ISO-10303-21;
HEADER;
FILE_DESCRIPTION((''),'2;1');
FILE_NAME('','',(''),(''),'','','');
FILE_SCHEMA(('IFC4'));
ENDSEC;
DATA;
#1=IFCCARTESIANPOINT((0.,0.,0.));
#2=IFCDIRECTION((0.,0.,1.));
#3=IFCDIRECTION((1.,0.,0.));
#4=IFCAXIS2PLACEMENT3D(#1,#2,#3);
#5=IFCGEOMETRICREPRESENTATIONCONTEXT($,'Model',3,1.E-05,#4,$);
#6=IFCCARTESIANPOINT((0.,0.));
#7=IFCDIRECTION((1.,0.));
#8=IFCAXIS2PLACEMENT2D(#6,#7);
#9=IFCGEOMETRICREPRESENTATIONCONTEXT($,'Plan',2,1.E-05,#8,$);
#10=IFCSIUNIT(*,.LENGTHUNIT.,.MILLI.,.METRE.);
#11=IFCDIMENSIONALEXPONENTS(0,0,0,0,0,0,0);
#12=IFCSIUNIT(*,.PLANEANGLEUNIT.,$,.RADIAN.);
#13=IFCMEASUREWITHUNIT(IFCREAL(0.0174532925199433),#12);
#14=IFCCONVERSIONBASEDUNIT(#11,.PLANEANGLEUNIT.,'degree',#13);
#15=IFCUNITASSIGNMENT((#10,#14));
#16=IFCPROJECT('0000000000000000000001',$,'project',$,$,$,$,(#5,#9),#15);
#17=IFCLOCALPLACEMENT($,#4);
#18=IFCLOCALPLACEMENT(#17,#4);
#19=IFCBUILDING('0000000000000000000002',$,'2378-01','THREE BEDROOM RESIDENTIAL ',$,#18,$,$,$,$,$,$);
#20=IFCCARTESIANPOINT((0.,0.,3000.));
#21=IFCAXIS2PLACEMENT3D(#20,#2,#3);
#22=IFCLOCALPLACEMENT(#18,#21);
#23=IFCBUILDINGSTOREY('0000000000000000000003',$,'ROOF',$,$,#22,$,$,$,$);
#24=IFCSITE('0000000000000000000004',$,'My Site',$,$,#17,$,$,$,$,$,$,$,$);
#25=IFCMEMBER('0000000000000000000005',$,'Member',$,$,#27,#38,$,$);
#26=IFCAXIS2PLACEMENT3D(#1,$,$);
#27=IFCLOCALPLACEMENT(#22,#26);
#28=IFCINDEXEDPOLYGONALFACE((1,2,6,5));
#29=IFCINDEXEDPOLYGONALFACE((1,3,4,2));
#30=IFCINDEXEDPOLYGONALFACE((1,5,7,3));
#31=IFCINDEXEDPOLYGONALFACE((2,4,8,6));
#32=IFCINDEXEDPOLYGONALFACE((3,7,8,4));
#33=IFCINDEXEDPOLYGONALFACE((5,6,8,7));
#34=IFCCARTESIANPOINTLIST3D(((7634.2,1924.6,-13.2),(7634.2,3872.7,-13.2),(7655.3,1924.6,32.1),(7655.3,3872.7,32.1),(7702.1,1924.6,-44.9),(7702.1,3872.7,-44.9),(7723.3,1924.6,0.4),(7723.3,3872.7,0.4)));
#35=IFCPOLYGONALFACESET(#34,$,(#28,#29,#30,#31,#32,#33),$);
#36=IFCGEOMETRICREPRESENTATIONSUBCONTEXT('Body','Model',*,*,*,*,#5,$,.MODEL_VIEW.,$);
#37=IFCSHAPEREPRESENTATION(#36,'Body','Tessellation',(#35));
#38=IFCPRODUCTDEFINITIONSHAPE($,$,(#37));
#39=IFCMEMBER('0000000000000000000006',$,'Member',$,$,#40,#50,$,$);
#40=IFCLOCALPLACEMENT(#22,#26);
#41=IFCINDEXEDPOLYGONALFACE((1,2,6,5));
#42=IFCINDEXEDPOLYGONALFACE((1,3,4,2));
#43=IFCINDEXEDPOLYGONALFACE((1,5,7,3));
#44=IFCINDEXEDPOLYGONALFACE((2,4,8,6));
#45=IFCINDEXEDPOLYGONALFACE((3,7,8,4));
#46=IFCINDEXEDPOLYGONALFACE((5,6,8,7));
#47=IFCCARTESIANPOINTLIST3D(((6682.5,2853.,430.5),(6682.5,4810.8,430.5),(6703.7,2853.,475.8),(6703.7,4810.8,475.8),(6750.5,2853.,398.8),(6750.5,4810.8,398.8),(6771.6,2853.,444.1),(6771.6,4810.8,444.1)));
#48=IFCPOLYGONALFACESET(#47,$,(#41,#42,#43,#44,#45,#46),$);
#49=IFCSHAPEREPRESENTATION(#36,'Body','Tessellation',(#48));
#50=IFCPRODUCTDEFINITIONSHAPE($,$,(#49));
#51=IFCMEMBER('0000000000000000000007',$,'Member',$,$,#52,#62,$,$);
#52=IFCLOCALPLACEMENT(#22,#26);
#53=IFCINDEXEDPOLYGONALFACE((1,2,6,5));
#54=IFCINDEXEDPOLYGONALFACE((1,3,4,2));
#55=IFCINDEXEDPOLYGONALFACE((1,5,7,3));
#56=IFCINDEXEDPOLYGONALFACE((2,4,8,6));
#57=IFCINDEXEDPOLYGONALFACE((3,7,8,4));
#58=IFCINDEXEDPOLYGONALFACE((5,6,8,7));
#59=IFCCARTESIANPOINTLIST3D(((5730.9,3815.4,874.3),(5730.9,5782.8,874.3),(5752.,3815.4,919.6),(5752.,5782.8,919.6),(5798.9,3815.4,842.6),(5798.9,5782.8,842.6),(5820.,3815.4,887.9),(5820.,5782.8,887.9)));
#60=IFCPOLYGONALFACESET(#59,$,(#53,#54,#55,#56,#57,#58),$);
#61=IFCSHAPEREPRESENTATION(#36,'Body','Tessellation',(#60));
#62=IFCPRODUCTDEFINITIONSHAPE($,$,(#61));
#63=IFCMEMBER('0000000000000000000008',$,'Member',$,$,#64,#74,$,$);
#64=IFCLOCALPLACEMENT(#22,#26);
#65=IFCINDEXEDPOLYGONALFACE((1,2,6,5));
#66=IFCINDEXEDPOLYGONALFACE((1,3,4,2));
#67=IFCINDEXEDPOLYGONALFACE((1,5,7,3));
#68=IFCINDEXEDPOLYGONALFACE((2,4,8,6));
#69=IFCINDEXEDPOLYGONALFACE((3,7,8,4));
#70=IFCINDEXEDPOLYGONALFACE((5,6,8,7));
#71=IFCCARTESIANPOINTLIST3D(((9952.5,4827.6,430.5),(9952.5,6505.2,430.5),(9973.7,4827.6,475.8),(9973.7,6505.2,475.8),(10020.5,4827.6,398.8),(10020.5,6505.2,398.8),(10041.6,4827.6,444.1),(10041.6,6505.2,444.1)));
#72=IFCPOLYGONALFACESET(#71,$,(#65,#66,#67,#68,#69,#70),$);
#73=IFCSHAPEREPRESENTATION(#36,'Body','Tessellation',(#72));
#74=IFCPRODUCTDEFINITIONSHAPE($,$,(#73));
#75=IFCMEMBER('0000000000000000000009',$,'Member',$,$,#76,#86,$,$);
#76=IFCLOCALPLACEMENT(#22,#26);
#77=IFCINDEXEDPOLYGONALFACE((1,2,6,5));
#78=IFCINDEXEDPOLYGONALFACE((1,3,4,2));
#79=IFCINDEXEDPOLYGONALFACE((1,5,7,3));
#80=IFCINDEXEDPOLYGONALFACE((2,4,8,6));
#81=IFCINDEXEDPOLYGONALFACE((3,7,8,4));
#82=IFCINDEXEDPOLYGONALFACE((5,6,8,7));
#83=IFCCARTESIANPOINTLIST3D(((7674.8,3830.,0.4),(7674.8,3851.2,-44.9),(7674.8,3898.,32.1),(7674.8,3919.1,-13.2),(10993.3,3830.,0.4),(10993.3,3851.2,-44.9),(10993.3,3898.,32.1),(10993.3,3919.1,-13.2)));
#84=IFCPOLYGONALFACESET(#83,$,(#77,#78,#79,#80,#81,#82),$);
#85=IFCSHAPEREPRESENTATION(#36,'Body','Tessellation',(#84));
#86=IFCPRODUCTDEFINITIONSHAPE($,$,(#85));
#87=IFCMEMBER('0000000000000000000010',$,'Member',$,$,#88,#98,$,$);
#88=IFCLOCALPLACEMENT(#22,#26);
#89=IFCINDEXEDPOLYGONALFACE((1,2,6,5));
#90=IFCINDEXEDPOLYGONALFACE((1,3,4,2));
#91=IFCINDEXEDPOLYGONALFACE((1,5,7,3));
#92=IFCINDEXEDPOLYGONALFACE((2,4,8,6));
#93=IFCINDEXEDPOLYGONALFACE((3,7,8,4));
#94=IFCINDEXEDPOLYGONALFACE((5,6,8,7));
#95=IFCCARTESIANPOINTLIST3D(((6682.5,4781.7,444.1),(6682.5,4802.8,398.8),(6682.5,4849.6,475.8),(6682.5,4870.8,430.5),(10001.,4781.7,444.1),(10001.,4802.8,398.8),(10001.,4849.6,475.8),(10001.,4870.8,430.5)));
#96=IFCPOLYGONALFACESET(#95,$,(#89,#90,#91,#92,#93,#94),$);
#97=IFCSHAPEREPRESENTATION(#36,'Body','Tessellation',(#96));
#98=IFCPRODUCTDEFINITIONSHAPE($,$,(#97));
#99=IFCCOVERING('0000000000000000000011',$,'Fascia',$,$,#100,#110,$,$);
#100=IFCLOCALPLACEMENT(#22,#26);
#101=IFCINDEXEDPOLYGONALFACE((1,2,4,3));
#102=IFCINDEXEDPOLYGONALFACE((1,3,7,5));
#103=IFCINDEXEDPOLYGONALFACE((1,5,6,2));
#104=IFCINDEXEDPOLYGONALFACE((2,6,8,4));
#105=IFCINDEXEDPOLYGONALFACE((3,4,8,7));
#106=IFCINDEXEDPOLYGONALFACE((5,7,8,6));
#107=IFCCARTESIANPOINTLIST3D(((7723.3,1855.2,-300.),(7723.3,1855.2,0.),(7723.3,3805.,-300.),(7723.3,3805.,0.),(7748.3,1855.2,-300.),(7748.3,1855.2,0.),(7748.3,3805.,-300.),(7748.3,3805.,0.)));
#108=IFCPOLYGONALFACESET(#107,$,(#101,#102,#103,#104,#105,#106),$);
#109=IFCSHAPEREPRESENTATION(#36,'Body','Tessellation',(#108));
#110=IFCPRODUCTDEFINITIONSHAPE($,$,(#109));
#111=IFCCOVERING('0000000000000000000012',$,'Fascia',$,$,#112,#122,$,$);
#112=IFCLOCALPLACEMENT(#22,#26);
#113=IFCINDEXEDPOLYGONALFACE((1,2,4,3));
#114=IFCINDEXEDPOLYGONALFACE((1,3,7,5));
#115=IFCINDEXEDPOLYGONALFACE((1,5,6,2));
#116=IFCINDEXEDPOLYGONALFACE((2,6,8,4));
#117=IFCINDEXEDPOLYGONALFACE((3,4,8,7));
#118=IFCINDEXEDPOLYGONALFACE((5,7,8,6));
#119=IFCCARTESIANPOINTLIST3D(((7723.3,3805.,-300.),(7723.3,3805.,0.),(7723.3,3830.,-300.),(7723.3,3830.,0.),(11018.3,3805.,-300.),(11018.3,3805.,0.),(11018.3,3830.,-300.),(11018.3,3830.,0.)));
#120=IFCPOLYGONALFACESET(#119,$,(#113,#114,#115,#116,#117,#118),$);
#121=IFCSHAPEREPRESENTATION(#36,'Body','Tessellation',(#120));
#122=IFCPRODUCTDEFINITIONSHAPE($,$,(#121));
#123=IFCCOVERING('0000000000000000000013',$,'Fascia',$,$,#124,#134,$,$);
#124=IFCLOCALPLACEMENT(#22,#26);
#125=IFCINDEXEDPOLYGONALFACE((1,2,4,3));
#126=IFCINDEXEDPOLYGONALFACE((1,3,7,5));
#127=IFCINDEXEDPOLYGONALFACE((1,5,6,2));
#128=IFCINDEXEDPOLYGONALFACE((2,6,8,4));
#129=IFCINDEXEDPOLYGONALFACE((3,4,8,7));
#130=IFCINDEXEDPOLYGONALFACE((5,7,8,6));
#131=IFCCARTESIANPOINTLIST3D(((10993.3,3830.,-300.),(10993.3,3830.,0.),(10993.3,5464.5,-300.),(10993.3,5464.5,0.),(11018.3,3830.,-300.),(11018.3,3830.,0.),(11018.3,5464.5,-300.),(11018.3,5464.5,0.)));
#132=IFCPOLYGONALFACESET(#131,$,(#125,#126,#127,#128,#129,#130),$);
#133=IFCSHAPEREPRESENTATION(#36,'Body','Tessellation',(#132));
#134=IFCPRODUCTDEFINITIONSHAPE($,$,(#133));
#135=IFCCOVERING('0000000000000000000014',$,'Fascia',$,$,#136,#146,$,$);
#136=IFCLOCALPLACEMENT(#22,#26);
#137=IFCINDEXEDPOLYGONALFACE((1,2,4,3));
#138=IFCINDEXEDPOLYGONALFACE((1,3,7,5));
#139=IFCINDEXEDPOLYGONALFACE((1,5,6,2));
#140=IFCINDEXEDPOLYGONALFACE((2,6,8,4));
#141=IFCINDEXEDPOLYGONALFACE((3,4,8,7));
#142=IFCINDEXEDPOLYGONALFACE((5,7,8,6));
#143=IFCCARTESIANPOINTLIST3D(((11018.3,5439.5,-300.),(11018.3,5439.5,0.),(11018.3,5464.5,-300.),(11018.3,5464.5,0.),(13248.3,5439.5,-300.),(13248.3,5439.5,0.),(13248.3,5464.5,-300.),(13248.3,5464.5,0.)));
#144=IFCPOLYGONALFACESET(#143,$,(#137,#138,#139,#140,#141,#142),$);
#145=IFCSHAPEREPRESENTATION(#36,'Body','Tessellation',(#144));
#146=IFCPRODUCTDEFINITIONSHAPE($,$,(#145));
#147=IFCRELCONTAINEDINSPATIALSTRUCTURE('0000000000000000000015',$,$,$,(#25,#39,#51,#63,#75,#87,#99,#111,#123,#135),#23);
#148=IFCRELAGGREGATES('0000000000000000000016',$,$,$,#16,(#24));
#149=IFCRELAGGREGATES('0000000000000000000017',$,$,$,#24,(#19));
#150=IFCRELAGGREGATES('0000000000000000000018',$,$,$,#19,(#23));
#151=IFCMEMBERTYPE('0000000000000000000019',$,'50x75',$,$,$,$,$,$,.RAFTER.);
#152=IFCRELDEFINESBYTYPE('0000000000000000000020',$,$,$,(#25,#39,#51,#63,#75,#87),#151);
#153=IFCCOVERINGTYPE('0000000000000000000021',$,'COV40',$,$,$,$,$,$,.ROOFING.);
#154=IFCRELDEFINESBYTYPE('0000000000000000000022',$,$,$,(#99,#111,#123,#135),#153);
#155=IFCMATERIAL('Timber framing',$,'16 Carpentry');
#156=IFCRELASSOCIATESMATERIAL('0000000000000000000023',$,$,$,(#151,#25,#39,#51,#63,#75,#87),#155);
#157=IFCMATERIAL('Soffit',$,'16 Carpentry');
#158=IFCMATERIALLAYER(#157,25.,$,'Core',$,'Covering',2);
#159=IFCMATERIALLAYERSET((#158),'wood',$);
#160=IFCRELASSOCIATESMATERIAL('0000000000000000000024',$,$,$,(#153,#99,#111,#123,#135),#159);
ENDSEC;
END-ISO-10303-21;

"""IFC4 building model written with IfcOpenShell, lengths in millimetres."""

from ifc_helpers import new_model, entity, si_unit, converted_unit, frame, origin_with_axes, origin_2d_with_axis, place, context, subcontext, project, spatial, indexed_curve, rectangle, outline, extrude, material, layer, layer_set, layer_usage, material_profile, profile_set, profile_usage, type_object, element, save


model = new_model("IFC4")

# Units and contexts
model_context = context("Model", 3, precision=1e-05, world=origin_with_axes())
plan_context = context("Plan", 2, precision=1e-05, world=origin_2d_with_axis())
body_context = subcontext(model_context, "Body", "Model", "MODEL_VIEW")
ifc_project = project(units=[si_unit("LENGTHUNIT", "METRE", prefix="MILLI"), converted_unit("PLANEANGLEUNIT", "degree", entity("IfcReal", 0.0174532925199433), si_unit("PLANEANGLEUNIT", "RADIAN"), dimensions=[0, 0, 0, 0, 0, 0, 0])], contexts=[model_context, plan_context])

# Site, building, storey
site_placement = place(None, origin_with_axes())
site = spatial("IfcSite", under=ifc_project, at=site_placement, Name="My Site")
building_placement = place(site_placement, origin_with_axes())
building = spatial("IfcBuilding", under=site, at=building_placement, Name="2378-01", Description="THREE BEDROOM RESIDENTIAL ")
storey_placement = place(building_placement, frame((0.0, 0.0, 3000.0), z_axis=(0.0, 0.0, 1.0), x_axis=(1.0, 0.0, 0.0)))
storey = spatial("IfcBuildingStorey", under=building, at=storey_placement, Name="ROOF")

# Members
ifc_material_1 = material(Name="Timber framing", Category="16 Carpentry")
ifc_material_profile_1 = material_profile(ifc_material_1, rectangle(XDim=50.0, YDim=75.0), Name="Lumber2", Category="Substrate", Priority=2)
ifc_profile_set_1 = profile_set([ifc_material_profile_1])
ifc_profile_usage_1 = profile_usage(ifc_profile_set_1, cardinal=5)
member_type_1 = type_object("IfcMemberType", Name="50x75", PredefinedType="RAFTER", material=ifc_profile_set_1)
member_1_placement = place(storey_placement, frame((7678.7, 1924.6, -6.4), z_axis=(0.0, 1.0, 0.0), x_axis=(-0.422618, 0.0, -0.906308)))
element("IfcMember", 1, at=member_1_placement, inside=storey, type_object=member_type_1, material=ifc_profile_usage_1, Name="Member", context=body_context, shape_type="SweptSolid", body=[
    extrude(rectangle(XDim=50.0, YDim=75.0), origin_with_axes(), (0.0, 0.0, 1.0), 1948.1),
])
ifc_profile_usage_2 = profile_usage(ifc_profile_set_1, cardinal=5)
member_2_placement = place(storey_placement, frame((6727.1, 2853.0, 437.3), z_axis=(0.0, 1.0, 0.0), x_axis=(-0.422618, 0.0, -0.906308)))
element("IfcMember", 2, at=member_2_placement, inside=storey, type_object=member_type_1, material=ifc_profile_usage_2, Name="Member", context=body_context, shape_type="SweptSolid", body=[
    extrude(rectangle(XDim=50.0, YDim=75.0), origin_with_axes(), (0.0, 0.0, 1.0), 1957.8),
])
ifc_profile_usage_3 = profile_usage(ifc_profile_set_1, cardinal=5)
member_3_placement = place(storey_placement, frame((5775.5, 3815.4, 881.1), z_axis=(0.0, 1.0, 0.0), x_axis=(-0.422618, 0.0, -0.906308)))
element("IfcMember", 3, at=member_3_placement, inside=storey, type_object=member_type_1, material=ifc_profile_usage_3, Name="Member", context=body_context, shape_type="SweptSolid", body=[
    extrude(rectangle(XDim=50.0, YDim=75.0), origin_with_axes(), (0.0, 0.0, 1.0), 1967.5),
])
ifc_profile_usage_4 = profile_usage(ifc_profile_set_1, cardinal=5)
member_4_placement = place(storey_placement, frame((9997.1, 4827.6, 437.3), z_axis=(0.0, 1.0, 0.0), x_axis=(-0.422618, 0.0, -0.906308)))
element("IfcMember", 4, at=member_4_placement, inside=storey, type_object=member_type_1, material=ifc_profile_usage_4, Name="Member", context=body_context, shape_type="SweptSolid", body=[
    extrude(rectangle(XDim=50.0, YDim=75.0), origin_with_axes(), (0.0, 0.0, 1.0), 1677.6),
])
ifc_profile_usage_5 = profile_usage(ifc_profile_set_1, cardinal=5)
member_5_placement = place(storey_placement, frame((7674.8, 3874.6, -6.4), z_axis=(1.0, 0.0, 0.0), x_axis=(0.0, 0.422618, -0.906308)))
element("IfcMember", 5, at=member_5_placement, inside=storey, type_object=member_type_1, material=ifc_profile_usage_5, Name="Member", context=body_context, shape_type="SweptSolid", body=[
    extrude(rectangle(XDim=50.0, YDim=75.0), origin_with_axes(), (0.0, 0.0, 1.0), 3318.5),
])
ifc_profile_usage_6 = profile_usage(ifc_profile_set_1, cardinal=5)
member_6_placement = place(storey_placement, frame((6682.5, 4826.2, 437.3), z_axis=(1.0, 0.0, 0.0), x_axis=(0.0, 0.422618, -0.906308)))
element("IfcMember", 6, at=member_6_placement, inside=storey, type_object=member_type_1, material=ifc_profile_usage_6, Name="Member", context=body_context, shape_type="SweptSolid", body=[
    extrude(rectangle(XDim=50.0, YDim=75.0), origin_with_axes(), (0.0, 0.0, 1.0), 3318.5),
])

# Coverings
ifc_material_2 = material(Name="Soffit", Category="16 Carpentry")
ifc_layer = layer(ifc_material_2, 25.0, Name="Core", Category="Covering", Priority=2)
ifc_layer_set = layer_set([ifc_layer], Name="wood")
ifc_layer_usage_1 = layer_usage(ifc_layer_set, "AXIS2", "POSITIVE", 0.0)
covering_type = type_object("IfcCoveringType", Name="COV40", PredefinedType="ROOFING", material=ifc_layer_set)
covering_1_placement = place(storey_placement, frame((7723.3, 3805.0, -300.0), z_axis=(0.0, 0.0, 1.0), x_axis=(0.0, -1.0, 0.0)))
element("IfcCovering", 7, at=covering_1_placement, inside=storey, type_object=covering_type, material=ifc_layer_usage_1, Name="Fascia", context=body_context, shape_type="SweptSolid", body=[
    extrude(outline(indexed_curve([(0.0, 0.0), (0.0, 25.0), (1949.8, 25.0), (1949.8, 0.0), (0.0, 0.0)], self_intersect=False)), origin_with_axes(), (0.0, 0.0, 1.0), 300.0),
])
ifc_layer_usage_2 = layer_usage(ifc_layer_set, "AXIS2", "POSITIVE", 0.0)
covering_2_placement = place(storey_placement, frame((7723.3, 3805.0, -300.0), z_axis=(0.0, 0.0, 1.0), x_axis=(1.0, 0.0, 0.0)))
element("IfcCovering", 8, at=covering_2_placement, inside=storey, type_object=covering_type, material=ifc_layer_usage_2, Name="Fascia", context=body_context, shape_type="SweptSolid", body=[
    extrude(outline(indexed_curve([(0.0, 0.0), (0.0, 25.0), (3295.0, 25.0), (3295.0, 0.0), (0.0, 0.0)], self_intersect=False)), origin_with_axes(), (0.0, 0.0, 1.0), 300.0),
])
ifc_layer_usage_3 = layer_usage(ifc_layer_set, "AXIS2", "POSITIVE", 0.0)
covering_3_placement = place(storey_placement, frame((10993.3, 5464.5, -300.0), z_axis=(0.0, 0.0, 1.0), x_axis=(0.0, -1.0, 0.0)))
element("IfcCovering", 9, at=covering_3_placement, inside=storey, type_object=covering_type, material=ifc_layer_usage_3, Name="Fascia", context=body_context, shape_type="SweptSolid", body=[
    extrude(outline(indexed_curve([(0.0, 0.0), (0.0, 25.0), (1634.5, 25.0), (1634.5, 0.0), (0.0, 0.0)], self_intersect=False)), origin_with_axes(), (0.0, 0.0, 1.0), 300.0),
])
ifc_layer_usage_4 = layer_usage(ifc_layer_set, "AXIS2", "POSITIVE", 0.0)
covering_4_placement = place(storey_placement, frame((11018.3, 5439.5, -300.0), z_axis=(0.0, 0.0, 1.0), x_axis=(1.0, 0.0, 0.0)))
element("IfcCovering", 10, at=covering_4_placement, inside=storey, type_object=covering_type, material=ifc_layer_usage_4, Name="Fascia", context=body_context, shape_type="SweptSolid", body=[
    extrude(outline(indexed_curve([(0.0, 0.0), (0.0, 25.0), (2230.0, 25.0), (2230.0, 0.0), (0.0, 0.0)], self_intersect=False)), origin_with_axes(), (0.0, 0.0, 1.0), 300.0),
])

save(model, "model.ifc")
